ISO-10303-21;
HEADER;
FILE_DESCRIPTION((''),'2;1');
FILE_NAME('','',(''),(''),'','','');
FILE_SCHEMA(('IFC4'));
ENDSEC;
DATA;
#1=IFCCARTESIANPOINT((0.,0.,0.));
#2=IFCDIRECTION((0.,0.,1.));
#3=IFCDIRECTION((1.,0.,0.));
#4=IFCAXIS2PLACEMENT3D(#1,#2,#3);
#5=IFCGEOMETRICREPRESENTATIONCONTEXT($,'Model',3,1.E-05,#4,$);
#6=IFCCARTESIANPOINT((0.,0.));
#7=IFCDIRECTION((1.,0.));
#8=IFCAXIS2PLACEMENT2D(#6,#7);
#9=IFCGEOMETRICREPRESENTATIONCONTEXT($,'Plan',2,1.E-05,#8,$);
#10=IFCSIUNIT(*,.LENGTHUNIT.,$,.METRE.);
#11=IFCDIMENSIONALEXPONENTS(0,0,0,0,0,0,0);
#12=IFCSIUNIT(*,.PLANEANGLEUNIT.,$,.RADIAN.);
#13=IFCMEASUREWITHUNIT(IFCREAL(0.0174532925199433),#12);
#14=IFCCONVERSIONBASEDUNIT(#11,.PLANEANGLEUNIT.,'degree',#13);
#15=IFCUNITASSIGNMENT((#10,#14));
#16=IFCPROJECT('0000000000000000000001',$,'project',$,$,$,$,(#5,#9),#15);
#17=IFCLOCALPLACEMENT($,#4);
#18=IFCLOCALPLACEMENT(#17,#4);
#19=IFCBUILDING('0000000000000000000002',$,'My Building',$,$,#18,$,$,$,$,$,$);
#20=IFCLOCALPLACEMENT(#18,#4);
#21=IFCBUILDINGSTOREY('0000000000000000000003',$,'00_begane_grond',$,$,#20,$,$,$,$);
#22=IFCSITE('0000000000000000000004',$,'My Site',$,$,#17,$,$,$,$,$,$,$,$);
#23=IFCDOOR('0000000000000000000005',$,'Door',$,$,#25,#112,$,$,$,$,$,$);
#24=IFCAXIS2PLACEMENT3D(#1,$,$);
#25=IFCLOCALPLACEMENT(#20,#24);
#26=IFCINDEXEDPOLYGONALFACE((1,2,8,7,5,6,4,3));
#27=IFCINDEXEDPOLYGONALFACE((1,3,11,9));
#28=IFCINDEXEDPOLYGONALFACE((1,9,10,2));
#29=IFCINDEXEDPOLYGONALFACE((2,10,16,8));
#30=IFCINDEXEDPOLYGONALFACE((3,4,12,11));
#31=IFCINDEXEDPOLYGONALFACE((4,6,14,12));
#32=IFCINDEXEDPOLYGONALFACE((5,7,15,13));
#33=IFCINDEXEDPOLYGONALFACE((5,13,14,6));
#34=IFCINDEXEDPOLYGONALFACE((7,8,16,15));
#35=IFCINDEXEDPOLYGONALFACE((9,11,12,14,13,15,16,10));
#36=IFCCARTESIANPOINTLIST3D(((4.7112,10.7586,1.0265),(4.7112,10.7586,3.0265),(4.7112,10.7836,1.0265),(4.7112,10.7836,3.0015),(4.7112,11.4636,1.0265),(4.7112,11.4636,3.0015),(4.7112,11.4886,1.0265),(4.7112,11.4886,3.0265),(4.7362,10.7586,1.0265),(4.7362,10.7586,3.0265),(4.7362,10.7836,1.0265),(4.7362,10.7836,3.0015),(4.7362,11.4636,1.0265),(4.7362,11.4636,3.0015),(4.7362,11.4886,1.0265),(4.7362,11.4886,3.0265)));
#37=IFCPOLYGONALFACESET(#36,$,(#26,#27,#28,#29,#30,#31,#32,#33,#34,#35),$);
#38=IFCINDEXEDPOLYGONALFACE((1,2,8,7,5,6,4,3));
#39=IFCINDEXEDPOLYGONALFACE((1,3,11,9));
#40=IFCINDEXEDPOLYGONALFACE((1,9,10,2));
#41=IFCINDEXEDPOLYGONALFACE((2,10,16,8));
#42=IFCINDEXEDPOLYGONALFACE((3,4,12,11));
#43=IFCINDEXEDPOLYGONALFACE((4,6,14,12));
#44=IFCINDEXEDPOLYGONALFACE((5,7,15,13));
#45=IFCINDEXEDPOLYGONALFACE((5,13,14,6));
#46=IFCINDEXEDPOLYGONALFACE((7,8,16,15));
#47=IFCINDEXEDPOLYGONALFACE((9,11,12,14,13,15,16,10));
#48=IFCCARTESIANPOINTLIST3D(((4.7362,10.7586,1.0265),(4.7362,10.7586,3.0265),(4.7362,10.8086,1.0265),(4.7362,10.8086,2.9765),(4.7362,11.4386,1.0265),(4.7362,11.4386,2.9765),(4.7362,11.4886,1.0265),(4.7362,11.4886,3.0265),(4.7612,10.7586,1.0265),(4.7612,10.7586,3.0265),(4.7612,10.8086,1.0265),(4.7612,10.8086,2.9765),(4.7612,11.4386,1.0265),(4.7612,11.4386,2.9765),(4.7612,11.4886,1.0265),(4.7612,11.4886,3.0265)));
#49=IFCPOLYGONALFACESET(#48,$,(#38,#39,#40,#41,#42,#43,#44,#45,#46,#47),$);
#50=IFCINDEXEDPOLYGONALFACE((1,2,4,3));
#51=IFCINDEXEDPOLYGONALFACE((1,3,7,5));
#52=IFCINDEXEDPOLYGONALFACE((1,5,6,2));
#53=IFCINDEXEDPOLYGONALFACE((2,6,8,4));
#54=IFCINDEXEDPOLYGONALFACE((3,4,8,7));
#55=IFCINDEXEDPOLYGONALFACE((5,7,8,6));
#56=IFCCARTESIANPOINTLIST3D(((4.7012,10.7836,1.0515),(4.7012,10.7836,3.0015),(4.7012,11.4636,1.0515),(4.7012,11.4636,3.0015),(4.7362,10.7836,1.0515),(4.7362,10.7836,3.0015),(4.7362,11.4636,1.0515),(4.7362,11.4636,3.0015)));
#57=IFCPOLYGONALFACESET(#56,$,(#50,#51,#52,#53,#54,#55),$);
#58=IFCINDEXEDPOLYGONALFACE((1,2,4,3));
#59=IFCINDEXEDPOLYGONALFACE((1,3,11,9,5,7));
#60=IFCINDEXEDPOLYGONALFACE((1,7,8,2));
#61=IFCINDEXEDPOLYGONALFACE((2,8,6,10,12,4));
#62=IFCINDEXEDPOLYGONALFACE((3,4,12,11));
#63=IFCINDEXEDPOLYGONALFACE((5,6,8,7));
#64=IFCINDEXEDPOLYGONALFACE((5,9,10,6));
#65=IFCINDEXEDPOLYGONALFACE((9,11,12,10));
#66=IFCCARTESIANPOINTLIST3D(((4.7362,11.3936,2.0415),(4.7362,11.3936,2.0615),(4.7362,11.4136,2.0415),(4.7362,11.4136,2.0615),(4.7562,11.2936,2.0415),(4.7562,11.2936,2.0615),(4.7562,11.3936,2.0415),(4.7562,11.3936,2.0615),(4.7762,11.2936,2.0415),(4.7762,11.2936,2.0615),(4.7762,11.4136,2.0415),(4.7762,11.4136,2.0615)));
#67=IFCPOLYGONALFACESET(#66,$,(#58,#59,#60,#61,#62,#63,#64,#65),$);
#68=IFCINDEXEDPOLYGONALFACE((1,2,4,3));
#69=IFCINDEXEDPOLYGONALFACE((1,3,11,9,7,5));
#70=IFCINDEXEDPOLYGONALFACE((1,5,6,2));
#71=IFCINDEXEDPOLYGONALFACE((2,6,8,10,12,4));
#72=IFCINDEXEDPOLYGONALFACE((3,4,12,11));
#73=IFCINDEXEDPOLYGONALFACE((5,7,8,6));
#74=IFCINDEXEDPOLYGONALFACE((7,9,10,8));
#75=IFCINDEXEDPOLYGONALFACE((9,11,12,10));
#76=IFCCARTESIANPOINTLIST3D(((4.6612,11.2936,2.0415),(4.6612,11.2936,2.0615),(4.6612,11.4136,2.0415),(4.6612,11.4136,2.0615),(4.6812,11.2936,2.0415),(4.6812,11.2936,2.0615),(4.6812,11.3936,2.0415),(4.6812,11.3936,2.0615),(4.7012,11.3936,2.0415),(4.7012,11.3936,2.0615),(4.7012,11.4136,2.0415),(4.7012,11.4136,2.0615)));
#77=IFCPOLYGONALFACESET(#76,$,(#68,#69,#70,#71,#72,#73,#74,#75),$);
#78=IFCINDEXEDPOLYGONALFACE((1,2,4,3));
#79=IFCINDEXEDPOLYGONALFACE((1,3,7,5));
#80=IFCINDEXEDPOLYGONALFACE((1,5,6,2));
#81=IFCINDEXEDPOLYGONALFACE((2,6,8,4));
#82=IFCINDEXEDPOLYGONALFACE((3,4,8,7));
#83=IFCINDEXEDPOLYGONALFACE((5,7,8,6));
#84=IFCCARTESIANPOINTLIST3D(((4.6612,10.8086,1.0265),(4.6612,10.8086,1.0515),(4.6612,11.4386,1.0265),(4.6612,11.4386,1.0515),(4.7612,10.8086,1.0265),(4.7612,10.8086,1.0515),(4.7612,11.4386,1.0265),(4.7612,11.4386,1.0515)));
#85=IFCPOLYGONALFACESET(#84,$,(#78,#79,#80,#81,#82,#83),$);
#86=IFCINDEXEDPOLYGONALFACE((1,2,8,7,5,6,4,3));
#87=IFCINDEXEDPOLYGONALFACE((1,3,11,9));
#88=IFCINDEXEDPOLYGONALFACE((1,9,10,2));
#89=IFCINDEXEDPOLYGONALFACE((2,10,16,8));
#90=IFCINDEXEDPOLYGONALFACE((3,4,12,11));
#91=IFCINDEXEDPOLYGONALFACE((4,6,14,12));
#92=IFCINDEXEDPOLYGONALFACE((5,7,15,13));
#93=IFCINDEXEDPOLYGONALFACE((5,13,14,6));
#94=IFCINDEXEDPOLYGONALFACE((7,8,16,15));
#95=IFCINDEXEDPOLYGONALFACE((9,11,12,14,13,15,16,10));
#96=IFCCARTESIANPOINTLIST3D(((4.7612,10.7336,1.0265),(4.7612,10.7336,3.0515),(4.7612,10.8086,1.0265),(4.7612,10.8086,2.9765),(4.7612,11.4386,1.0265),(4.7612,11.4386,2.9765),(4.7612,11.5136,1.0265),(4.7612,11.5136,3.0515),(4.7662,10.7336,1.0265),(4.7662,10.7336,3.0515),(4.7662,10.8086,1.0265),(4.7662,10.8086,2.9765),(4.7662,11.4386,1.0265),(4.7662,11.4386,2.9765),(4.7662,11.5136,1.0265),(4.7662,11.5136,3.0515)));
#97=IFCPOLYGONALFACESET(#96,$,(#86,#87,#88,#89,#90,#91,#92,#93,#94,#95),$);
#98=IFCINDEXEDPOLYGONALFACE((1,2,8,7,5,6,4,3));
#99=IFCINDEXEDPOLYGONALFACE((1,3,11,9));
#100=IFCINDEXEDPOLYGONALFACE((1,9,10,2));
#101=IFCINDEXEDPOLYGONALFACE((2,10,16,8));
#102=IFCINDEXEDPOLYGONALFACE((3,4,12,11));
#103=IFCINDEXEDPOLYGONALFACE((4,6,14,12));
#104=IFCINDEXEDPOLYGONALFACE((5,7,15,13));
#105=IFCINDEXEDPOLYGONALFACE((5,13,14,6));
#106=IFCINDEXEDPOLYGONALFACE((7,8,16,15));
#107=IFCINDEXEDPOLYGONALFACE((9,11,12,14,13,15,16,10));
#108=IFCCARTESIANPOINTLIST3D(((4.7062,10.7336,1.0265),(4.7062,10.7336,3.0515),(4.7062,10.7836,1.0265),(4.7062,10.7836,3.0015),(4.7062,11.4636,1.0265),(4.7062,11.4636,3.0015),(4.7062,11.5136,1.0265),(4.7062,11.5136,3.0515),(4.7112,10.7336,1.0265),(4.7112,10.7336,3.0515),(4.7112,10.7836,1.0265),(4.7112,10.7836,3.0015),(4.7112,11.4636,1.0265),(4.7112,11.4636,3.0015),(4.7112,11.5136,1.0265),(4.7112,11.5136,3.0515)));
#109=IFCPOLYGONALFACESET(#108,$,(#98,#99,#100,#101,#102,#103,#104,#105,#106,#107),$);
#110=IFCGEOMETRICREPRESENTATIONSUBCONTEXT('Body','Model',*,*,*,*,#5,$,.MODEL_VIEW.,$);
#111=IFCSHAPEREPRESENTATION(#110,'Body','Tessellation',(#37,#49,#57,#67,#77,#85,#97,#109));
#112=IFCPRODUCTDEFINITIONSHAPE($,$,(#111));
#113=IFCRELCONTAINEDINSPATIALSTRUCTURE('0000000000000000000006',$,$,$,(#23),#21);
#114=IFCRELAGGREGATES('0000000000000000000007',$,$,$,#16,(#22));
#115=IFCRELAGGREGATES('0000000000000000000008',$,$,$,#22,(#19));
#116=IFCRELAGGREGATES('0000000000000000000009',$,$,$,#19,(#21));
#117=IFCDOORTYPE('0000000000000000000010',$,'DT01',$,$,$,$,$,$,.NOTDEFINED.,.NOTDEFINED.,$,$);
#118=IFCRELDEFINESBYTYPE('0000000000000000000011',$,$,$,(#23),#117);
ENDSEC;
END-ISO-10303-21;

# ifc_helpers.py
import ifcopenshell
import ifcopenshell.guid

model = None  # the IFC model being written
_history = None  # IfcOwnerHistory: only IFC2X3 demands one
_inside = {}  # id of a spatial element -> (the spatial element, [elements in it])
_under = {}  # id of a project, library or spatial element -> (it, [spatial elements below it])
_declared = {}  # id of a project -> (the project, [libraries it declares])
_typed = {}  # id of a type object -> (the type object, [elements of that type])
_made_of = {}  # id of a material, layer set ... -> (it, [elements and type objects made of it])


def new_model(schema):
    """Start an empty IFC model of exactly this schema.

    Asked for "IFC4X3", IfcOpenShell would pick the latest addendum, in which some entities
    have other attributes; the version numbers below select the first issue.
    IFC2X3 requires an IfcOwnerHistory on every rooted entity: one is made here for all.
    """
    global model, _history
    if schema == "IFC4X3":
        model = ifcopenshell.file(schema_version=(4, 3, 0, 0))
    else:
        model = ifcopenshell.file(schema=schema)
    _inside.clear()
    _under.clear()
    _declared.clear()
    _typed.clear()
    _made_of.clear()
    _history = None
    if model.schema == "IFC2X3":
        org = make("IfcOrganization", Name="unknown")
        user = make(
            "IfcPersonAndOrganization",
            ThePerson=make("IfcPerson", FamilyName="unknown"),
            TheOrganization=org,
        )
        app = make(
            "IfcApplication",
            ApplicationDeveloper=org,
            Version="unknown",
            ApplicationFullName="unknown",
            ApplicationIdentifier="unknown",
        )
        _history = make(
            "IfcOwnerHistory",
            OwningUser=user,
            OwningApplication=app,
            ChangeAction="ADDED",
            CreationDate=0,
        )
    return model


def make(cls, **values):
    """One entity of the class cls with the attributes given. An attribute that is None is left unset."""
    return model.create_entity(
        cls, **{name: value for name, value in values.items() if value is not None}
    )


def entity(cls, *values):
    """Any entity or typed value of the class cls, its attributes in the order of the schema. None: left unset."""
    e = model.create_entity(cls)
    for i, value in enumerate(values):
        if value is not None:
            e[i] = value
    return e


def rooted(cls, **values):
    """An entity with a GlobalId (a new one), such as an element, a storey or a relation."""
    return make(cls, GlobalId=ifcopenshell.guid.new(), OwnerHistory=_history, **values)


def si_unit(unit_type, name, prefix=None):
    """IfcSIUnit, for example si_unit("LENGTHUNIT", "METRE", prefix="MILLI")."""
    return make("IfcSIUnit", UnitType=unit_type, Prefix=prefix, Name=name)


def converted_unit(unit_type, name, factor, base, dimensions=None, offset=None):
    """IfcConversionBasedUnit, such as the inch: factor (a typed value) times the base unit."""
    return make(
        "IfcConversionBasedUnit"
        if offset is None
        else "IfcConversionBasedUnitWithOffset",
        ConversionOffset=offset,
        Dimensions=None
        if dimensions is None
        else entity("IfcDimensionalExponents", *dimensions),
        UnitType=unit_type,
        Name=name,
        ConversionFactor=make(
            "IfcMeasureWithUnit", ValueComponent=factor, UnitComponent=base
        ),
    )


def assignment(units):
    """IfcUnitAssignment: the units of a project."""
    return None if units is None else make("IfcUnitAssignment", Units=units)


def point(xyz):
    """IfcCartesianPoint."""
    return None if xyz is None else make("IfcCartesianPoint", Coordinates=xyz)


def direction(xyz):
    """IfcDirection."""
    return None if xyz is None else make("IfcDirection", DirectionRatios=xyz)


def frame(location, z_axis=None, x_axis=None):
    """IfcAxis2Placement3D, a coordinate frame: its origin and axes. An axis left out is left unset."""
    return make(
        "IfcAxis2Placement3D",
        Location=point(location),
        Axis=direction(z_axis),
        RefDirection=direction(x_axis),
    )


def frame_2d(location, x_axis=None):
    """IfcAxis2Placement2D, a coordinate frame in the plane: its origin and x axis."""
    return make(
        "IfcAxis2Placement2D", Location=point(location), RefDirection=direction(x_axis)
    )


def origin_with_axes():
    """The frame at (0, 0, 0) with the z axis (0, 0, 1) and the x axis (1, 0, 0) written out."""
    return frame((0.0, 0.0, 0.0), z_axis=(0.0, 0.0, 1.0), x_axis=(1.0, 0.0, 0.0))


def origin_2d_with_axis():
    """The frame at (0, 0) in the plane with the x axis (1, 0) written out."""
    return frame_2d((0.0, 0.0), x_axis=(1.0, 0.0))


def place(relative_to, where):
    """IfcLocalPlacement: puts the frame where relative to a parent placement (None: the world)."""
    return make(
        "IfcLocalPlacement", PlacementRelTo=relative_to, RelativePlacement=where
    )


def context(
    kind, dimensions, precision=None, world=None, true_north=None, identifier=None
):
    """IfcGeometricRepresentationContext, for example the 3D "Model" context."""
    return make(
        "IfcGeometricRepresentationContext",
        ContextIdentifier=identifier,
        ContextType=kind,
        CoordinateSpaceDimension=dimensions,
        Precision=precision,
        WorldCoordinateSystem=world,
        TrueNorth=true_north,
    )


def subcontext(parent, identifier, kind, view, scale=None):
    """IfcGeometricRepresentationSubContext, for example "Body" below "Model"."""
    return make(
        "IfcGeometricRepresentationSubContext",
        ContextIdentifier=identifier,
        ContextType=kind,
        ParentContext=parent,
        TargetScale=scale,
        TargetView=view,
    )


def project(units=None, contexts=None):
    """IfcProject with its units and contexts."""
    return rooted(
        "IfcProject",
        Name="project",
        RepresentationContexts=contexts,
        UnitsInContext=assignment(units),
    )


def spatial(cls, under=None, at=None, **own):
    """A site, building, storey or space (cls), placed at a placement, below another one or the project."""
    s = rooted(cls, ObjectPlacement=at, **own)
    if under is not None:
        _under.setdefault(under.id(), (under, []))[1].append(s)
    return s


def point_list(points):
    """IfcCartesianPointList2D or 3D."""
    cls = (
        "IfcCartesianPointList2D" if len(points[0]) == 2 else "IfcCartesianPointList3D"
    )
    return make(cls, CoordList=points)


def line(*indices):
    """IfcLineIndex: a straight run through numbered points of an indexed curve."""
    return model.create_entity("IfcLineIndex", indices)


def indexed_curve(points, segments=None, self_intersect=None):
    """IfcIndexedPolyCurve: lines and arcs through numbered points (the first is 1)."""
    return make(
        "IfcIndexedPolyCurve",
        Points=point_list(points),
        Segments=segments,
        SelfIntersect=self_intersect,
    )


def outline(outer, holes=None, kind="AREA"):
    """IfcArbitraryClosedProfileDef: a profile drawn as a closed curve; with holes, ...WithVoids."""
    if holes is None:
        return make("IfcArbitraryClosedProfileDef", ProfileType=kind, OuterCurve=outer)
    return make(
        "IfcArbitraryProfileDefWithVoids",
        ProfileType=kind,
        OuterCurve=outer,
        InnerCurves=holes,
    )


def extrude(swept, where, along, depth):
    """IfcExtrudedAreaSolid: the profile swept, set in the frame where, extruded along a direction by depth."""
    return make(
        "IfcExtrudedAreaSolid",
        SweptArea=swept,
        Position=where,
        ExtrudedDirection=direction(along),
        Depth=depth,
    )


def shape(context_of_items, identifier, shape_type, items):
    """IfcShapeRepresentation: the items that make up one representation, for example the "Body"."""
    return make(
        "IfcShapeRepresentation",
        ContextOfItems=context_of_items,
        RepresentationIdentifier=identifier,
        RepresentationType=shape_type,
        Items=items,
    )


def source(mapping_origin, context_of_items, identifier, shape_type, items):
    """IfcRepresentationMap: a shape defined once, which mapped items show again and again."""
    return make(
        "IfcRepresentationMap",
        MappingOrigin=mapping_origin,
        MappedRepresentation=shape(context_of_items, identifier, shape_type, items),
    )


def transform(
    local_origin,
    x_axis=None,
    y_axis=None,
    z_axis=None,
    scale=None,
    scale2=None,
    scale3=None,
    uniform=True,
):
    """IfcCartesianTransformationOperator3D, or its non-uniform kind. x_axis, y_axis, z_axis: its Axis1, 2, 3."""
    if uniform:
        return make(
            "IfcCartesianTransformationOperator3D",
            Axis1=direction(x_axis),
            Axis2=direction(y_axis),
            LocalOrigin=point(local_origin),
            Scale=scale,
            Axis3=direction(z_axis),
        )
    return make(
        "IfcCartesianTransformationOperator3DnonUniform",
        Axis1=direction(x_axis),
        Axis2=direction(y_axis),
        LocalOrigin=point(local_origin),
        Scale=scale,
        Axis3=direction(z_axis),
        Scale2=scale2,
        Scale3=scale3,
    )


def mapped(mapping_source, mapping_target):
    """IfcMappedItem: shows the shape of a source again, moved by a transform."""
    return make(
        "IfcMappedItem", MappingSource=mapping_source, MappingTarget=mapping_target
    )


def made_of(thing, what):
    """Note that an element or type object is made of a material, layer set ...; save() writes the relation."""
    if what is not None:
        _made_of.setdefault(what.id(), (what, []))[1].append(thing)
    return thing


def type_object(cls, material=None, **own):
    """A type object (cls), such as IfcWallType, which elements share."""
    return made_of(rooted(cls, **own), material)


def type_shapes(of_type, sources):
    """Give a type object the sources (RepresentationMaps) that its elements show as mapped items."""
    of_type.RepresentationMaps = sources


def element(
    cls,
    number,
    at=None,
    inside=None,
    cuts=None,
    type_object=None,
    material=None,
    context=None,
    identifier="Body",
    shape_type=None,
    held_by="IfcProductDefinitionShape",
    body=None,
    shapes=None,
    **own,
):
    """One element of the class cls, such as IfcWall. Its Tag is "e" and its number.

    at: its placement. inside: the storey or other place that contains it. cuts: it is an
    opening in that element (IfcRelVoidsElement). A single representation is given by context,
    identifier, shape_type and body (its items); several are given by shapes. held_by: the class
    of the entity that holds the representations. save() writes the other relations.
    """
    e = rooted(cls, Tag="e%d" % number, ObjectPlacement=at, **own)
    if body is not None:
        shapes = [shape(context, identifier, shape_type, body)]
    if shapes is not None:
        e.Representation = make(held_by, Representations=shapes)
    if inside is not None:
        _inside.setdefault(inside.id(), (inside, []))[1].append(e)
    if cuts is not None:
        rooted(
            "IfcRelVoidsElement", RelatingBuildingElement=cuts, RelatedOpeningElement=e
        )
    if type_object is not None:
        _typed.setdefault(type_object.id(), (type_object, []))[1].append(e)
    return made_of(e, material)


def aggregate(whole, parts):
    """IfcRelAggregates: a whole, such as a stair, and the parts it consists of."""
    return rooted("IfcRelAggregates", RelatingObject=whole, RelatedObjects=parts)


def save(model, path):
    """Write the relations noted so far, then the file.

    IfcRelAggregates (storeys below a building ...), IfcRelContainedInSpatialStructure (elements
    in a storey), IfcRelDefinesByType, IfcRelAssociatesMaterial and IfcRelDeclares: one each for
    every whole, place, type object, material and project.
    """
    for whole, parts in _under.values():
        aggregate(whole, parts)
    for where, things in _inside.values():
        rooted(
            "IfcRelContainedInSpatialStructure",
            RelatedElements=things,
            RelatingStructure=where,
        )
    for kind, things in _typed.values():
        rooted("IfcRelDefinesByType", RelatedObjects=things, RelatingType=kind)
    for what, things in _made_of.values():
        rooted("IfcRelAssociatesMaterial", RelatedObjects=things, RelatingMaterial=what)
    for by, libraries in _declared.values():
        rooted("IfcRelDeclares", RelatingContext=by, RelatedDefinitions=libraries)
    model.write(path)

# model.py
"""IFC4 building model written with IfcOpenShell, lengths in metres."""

from ifc_helpers import new_model, entity, si_unit, converted_unit, frame, origin_with_axes, origin_2d_with_axis, place, context, subcontext, project, spatial, line, indexed_curve, outline, extrude, shape, source, transform, mapped, type_object, type_shapes, element, save


model = new_model("IFC4")

# Units and contexts
model_context = context("Model", 3, precision=1e-05, world=origin_with_axes())
plan_context = context("Plan", 2, precision=1e-05, world=origin_2d_with_axis())
body_context_1 = subcontext(model_context, "Body", "Model", "MODEL_VIEW")
body_context_2 = subcontext(plan_context, "Body", "Plan", "PLAN_VIEW")
ifc_project = project(units=[si_unit("LENGTHUNIT", "METRE"), converted_unit("PLANEANGLEUNIT", "degree", entity("IfcReal", 0.0174532925199433), si_unit("PLANEANGLEUNIT", "RADIAN"), dimensions=[0, 0, 0, 0, 0, 0, 0])], contexts=[model_context, plan_context])

# Site, building, storey
site_placement = place(None, origin_with_axes())
site = spatial("IfcSite", under=ifc_project, at=site_placement, Name="My Site")
building_placement = place(site_placement, origin_with_axes())
building = spatial("IfcBuilding", under=site, at=building_placement, Name="My Building")
storey_placement = place(building_placement, origin_with_axes())
storey = spatial("IfcBuildingStorey", under=building, at=storey_placement, Name="00_begane_grond")

# Shared definitions
door_type_1 = type_object("IfcDoorType", Name="DT01", OperationType="NOTDEFINED", PredefinedType="NOTDEFINED")
shared_shape_1 = source(origin_with_axes(), body_context_1, "Body", "SweptSolid", [
    extrude(outline(indexed_curve([(0.025, 0.0), (0.025, 1.975), (0.705, 1.975), (0.705, 0.0), (0.73, 0.0), (0.73, 2.0), (0.0, 2.0), (0.0, 0.0)], segments=[line(3, 2), line(2, 1), line(1, 8), line(8, 7), line(7, 6), line(6, 5), line(5, 4), line(4, 3)], self_intersect=False)), frame((0.0, 0.025, 0.0), z_axis=(0.0, -1.0, 0.0), x_axis=(1.0, 0.0, 0.0)), (0.0, 0.0, -1.0), 0.025),
    extrude(outline(indexed_curve([(0.0, 0.0), (0.0, 2.0), (0.73, 2.0), (0.73, 0.0), (0.68, 0.0), (0.68, 1.95), (0.05, 1.95), (0.05, 0.0)], segments=[line(1, 2, 3, 4, 5, 6, 7, 8, 1)])), frame((0.0, 0.0, 0.0), z_axis=(0.0, -1.0, 0.0), x_axis=(1.0, 0.0, 0.0)), (0.0, 0.0, -1.0), 0.025),
    extrude(outline(indexed_curve([(0.0, 0.0), (0.68, 0.0), (0.68, 0.035), (0.0, 0.035)], segments=[line(1, 2, 3, 4, 1)])), frame((0.025, 0.025, 0.025), z_axis=(0.0, 0.0, 1.0), x_axis=(1.0, 0.0, 0.0)), (0.0, 0.0, 1.0), 1.95),
    extrude(outline(indexed_curve([(0.0, 0.0), (0.0, -0.04), (-0.12, -0.04), (-0.12, -0.02), (-0.02, -0.02), (-0.02, 0.0)], segments=[line(1, 2, 3, 4, 5, 6, 1)])), frame((0.655, 0.025, 1.015), z_axis=(0.0, 0.0, 1.0), x_axis=(1.0, 0.0, 0.0)), (0.0, 0.0, 1.0), 0.02),
    extrude(outline(indexed_curve([(0.0, 0.0), (0.0, 0.04), (-0.12, 0.04), (-0.12, 0.02), (-0.02, 0.02), (-0.02, 0.0)], segments=[line(1, 2, 3, 4, 5, 6, 1)])), frame((0.655, 0.06, 1.015), z_axis=(0.0, 0.0, 1.0), x_axis=(1.0, 0.0, 0.0)), (0.0, 0.0, 1.0), 0.02),
    extrude(outline(indexed_curve([(0.0, 0.0), (0.63, 0.0), (0.63, 0.1), (0.0, 0.1)], segments=[line(1, 2, 3, 4, 1)])), frame((0.05, 0.0, 0.0), z_axis=(0.0, 0.0, 1.0), x_axis=(1.0, 0.0, 0.0)), (0.0, 0.0, 1.0), 0.025),
    extrude(outline(indexed_curve([(0.0, 0.0), (0.0, 2.025), (0.78, 2.025), (0.78, 0.0), (0.705, 0.0), (0.705, 1.95), (0.075, 1.95), (0.075, 0.0)], segments=[line(1, 2, 3, 4, 5, 6, 7, 8, 1)])), frame((-0.025, -0.005, 0.0), z_axis=(0.0, -1.0, 0.0), x_axis=(1.0, 0.0, 0.0)), (0.0, 0.0, -1.0), 0.005),
    extrude(outline(indexed_curve([(0.0, 0.0), (0.0, 2.025), (0.78, 2.025), (0.78, 0.0), (0.73, 0.0), (0.73, 1.975), (0.05, 1.975), (0.05, 0.0)], segments=[line(1, 2, 3, 4, 5, 6, 7, 8, 1)])), frame((-0.025, 0.05, 0.0), z_axis=(0.0, -1.0, 0.0), x_axis=(1.0, 0.0, 0.0)), (0.0, 0.0, -1.0), 0.005),
])
shared_shape_2 = source(origin_with_axes(), body_context_2, "Body", "Curve2D", [
    entity("IfcIndexedPolyCurve", entity("IfcCartesianPointList2D", [[0.0, 0.0], [0.0, 0.05], [0.025, 0.05], [0.025, 0.025], [0.05, 0.025], [0.05, 0.0]]), [entity("IfcLineIndex", [1, 2, 3, 4, 5, 6, 1])]),
    entity("IfcIndexedPolyCurve", entity("IfcCartesianPointList2D", [[0.73, 0.0], [0.73, 0.05], [0.705, 0.05], [0.705, 0.025], [0.68, 0.025], [0.68, 0.0]]), [entity("IfcLineIndex", [1, 2, 3, 4, 5, 6, 1])]),
    entity("IfcTrimmedCurve", entity("IfcEllipse", entity("IfcAxis2Placement2D", entity("IfcCartesianPoint", [0.06, 0.05]), entity("IfcDirection", [1.0, 0.0])), 0.645, 0.68), [entity("IfcCartesianPoint", [0.705, 0.05])], [entity("IfcCartesianPoint", [0.06, 0.73])], True, "CARTESIAN"),
    entity("IfcIndexedPolyCurve", entity("IfcCartesianPointList2D", [[0.025, 0.05], [0.06, 0.05], [0.06, 0.73], [0.025, 0.73]]), [entity("IfcLineIndex", [1, 2, 3, 4, 1])]),
])
type_shapes(door_type_1, [shared_shape_1, shared_shape_2])

# Door
door_1_placement = place(storey_placement, frame((4.7612, 10.7586, 1.0265), z_axis=(0.0, 0.0, 1.0), x_axis=(0.000073, 1.0, 0.0)))
element("IfcDoor", 1, at=door_1_placement, inside=storey, type_object=door_type_1, Name="Door", shapes=[
    shape(body_context_1, "Body", "MappedRepresentation", [mapped(shared_shape_1, transform((0.0, 0.0, 0.0), x_axis=(1.0, 0.0, 0.0), y_axis=(0.0, 1.0, 0.0), z_axis=(0.0, 0.0, 1.0), scale=1.0))]),
    shape(body_context_2, "Body", "MappedRepresentation", [mapped(shared_shape_2, transform((0.0, 0.0, 0.0), x_axis=(1.0, 0.0, 0.0), y_axis=(0.0, 1.0, 0.0), z_axis=(0.0, 0.0, 1.0), scale=1.0))]),
])

save(model, "model.ifc")
